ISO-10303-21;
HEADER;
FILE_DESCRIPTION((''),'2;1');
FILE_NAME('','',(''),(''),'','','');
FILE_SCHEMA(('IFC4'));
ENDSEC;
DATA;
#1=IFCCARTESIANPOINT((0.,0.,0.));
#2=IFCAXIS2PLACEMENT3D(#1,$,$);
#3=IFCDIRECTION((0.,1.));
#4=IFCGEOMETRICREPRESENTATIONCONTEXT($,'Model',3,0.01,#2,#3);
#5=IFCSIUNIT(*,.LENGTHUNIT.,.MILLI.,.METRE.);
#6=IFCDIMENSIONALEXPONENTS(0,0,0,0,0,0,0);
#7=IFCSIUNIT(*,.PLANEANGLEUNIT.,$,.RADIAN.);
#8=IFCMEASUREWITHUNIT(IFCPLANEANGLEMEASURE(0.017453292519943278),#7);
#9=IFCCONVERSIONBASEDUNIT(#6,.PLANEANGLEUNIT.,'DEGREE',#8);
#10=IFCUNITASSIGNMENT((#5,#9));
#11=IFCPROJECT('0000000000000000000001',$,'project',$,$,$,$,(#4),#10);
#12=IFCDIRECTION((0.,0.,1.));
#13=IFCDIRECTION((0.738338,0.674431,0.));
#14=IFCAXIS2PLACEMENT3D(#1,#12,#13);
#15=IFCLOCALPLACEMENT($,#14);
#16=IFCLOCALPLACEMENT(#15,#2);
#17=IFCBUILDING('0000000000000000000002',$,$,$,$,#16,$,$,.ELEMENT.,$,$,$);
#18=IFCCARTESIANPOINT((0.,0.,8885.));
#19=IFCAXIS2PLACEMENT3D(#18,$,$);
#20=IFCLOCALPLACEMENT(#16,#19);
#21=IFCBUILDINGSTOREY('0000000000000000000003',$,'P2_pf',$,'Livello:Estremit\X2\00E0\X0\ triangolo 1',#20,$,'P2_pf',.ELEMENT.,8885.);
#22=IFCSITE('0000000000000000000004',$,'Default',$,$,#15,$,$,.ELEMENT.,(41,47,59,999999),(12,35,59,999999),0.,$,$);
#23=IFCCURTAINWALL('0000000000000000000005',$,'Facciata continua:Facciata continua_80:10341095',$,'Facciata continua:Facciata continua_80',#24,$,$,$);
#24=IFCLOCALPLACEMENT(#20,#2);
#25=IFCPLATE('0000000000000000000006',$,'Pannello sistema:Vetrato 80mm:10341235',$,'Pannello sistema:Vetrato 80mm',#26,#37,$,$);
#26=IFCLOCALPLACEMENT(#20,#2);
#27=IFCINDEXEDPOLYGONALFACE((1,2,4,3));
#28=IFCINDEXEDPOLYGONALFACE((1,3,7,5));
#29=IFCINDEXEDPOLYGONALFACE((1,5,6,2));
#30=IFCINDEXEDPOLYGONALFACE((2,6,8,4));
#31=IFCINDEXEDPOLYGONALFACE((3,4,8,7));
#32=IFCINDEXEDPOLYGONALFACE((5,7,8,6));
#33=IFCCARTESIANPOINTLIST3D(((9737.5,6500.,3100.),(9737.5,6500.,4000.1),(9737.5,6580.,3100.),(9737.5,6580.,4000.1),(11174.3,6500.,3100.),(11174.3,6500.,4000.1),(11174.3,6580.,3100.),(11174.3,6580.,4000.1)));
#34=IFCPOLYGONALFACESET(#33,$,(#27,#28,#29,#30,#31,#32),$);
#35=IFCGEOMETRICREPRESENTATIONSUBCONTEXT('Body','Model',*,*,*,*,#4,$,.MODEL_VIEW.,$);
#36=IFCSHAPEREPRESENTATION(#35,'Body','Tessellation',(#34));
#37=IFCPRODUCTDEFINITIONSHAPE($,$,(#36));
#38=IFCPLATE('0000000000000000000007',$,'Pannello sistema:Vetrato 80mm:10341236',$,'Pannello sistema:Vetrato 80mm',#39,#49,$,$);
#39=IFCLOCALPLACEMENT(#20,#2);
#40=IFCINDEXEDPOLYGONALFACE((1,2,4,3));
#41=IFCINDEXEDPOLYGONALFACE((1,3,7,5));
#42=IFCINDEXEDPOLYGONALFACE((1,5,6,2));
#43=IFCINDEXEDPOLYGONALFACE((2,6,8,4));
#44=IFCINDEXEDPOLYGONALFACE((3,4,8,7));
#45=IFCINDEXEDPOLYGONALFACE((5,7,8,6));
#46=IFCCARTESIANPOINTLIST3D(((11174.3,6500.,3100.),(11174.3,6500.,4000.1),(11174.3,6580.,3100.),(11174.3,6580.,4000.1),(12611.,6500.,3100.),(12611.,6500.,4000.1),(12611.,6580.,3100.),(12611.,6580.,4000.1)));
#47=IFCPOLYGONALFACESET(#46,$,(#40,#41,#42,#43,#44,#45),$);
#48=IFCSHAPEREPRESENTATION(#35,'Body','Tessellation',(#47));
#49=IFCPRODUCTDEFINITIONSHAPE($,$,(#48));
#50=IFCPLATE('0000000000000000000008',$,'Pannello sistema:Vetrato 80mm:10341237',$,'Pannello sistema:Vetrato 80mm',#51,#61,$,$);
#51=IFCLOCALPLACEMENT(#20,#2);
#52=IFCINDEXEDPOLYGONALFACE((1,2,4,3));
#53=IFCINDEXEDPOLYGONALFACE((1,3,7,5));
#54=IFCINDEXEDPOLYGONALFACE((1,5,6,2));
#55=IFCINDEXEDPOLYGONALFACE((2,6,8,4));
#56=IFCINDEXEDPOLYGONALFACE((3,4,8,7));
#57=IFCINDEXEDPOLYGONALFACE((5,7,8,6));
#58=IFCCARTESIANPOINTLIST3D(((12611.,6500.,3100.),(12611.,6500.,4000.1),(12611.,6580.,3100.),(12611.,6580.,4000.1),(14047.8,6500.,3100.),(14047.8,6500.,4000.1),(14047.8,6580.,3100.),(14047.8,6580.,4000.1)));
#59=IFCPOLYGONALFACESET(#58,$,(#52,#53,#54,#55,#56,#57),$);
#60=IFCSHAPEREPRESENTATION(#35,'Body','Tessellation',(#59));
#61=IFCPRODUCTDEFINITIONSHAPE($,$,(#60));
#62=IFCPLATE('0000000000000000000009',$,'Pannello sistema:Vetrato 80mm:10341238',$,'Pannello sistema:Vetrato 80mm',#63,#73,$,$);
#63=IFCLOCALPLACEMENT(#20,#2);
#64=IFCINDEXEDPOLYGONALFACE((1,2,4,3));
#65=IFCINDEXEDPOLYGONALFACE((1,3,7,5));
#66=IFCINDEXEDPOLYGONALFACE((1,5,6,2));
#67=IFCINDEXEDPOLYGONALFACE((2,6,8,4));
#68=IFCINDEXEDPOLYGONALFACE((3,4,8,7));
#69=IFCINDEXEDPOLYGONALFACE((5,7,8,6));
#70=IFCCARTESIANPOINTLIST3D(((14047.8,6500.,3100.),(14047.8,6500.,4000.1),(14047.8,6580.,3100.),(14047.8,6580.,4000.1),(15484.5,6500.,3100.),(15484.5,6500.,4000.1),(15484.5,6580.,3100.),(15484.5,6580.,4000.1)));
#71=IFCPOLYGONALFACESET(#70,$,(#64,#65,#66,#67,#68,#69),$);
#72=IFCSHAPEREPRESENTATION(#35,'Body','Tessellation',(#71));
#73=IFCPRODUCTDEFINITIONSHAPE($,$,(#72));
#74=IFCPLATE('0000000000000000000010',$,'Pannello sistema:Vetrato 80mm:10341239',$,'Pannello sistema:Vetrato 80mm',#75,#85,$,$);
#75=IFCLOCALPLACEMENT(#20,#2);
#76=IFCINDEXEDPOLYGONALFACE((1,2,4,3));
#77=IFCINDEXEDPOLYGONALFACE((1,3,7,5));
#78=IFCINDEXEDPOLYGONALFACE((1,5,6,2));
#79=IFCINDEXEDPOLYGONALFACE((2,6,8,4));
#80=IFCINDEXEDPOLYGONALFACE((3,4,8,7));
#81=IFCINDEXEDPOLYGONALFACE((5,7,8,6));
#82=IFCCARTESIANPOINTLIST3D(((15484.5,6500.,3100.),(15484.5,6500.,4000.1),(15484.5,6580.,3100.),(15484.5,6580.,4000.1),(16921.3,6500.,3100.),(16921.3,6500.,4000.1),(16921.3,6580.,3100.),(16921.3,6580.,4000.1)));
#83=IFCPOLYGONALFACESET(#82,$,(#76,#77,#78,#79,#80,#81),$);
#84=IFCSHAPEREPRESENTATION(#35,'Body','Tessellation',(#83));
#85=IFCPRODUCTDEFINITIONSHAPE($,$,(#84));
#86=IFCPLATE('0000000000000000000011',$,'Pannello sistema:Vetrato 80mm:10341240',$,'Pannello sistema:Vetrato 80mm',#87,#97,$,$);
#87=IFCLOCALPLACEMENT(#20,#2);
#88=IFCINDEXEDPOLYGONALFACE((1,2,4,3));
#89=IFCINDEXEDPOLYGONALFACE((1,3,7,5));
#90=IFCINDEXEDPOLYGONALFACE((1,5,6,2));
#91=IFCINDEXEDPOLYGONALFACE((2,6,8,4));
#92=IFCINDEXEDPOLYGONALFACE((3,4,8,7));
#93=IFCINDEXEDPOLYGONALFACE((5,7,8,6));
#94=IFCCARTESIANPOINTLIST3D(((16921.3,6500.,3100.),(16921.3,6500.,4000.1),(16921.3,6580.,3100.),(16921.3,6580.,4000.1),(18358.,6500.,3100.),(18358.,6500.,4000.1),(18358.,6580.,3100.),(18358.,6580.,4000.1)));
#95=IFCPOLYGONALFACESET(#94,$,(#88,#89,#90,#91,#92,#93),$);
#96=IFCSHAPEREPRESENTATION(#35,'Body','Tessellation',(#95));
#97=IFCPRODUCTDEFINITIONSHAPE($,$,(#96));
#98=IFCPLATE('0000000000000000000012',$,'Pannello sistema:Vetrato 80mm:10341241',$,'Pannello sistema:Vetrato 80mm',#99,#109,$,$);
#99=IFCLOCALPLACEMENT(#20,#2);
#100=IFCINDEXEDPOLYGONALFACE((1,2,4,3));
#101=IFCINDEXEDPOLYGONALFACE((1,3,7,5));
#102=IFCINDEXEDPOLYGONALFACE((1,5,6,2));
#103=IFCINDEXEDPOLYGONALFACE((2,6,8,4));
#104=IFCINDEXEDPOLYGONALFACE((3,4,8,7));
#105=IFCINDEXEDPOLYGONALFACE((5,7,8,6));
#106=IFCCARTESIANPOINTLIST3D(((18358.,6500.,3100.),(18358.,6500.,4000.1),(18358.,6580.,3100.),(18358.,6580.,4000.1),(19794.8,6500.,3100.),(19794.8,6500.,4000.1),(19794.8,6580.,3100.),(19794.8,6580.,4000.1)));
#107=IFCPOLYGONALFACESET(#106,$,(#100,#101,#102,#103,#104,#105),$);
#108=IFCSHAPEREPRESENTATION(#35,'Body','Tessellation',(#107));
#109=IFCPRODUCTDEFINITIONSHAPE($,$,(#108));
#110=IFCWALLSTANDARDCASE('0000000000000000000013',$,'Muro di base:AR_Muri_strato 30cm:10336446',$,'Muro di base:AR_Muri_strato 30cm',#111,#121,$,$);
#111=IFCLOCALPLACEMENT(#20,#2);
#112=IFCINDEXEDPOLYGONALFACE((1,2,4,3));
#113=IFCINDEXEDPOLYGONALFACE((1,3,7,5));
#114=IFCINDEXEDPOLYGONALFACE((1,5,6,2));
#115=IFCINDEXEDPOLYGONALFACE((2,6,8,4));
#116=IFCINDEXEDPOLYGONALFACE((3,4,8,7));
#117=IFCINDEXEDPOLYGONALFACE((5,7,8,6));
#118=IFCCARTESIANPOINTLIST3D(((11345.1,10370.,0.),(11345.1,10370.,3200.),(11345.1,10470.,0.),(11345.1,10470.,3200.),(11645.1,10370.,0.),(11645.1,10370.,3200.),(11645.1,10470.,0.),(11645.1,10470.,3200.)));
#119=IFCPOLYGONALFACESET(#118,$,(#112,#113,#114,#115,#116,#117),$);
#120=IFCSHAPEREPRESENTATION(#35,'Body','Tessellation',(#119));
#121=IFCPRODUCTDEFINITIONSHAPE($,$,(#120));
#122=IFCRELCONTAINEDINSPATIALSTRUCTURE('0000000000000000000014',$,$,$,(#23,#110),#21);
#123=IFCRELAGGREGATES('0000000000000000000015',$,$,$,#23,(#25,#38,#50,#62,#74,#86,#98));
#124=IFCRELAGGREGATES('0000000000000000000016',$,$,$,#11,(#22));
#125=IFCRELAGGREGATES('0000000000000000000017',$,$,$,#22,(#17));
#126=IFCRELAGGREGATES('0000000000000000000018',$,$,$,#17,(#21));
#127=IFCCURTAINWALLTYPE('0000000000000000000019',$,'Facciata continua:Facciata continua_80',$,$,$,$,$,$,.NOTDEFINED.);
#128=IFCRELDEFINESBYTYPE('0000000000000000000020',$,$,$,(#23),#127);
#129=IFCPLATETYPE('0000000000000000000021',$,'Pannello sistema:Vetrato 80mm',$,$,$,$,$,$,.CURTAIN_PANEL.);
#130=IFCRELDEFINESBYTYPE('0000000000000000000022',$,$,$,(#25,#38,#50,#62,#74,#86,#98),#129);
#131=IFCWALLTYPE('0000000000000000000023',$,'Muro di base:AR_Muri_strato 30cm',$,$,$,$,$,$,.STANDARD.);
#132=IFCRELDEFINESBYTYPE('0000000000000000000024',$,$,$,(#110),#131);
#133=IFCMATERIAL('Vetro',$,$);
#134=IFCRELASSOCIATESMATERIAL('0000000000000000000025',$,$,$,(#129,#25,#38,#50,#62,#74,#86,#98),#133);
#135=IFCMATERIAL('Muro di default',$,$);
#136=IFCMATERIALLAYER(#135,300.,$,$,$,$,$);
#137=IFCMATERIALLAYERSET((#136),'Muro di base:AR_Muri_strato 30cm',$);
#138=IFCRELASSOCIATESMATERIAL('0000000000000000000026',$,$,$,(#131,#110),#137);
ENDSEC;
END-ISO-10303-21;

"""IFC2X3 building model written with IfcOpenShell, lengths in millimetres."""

from ifc_helpers import new_model, entity, si_unit, converted_unit, direction, frame, frame_2d, origin, origin_2d_with_axis, place, context, subcontext, project, spatial, rectangle, extrude, source, transform, mapped, material, layer, layer_set, layer_usage, type_object, type_shapes, element, aggregate, save


model = new_model("IFC2X3")

# Units and contexts
model_context = context("Model", 3, precision=0.01, world=origin(), true_north=direction((0.0, 1.0)))
body_context = subcontext(model_context, "Body", "Model", "MODEL_VIEW")
ifc_project = project(units=[si_unit("LENGTHUNIT", "METRE", prefix="MILLI"), converted_unit("PLANEANGLEUNIT", "DEGREE", entity("IfcPlaneAngleMeasure", 0.017453292519943278), si_unit("PLANEANGLEUNIT", "RADIAN"), dimensions=[0, 0, 0, 0, 0, 0, 0])], contexts=[model_context])

# Site, building, storey
site_placement = place(None, frame((0.0, 0.0, 0.0), z_axis=(0.0, 0.0, 1.0), x_axis=(0.738338, 0.674431, 0.0)))
site = spatial("IfcSite", under=ifc_project, at=site_placement, Name="Default", CompositionType="ELEMENT", RefLatitude=(41, 47, 59, 999999), RefLongitude=(12, 35, 59, 999999), RefElevation=0.0)
building_placement = place(site_placement, origin())
building = spatial("IfcBuilding", under=site, at=building_placement, CompositionType="ELEMENT")
storey_placement = place(building_placement, frame((0.0, 0.0, 8885.0)))
storey = spatial("IfcBuildingStorey", under=building, at=storey_placement, Name="P2_pf", ObjectType="Livello:Estremità triangolo 1", LongName="P2_pf", CompositionType="ELEMENT", Elevation=8885.0)

# Curtain wall, plates
curtain_wall_type = type_object("IfcCurtainWallType", Name="Facciata continua:Facciata continua_80", PredefinedType="NOTDEFINED")
curtain_wall_placement = place(storey_placement, frame((0.0, 0.0, -8885.0)))
curtain_wall = element("IfcCurtainWall", 1, at=curtain_wall_placement, inside=storey, type_object=curtain_wall_type, Name="Facciata continua:Facciata continua_80:10341095", ObjectType="Facciata continua:Facciata continua_80")
ifc_material_1 = material(Name="Vetro")
plate_type_1 = type_object("IfcPlateType", Name="Pannello sistema:Vetrato 80mm", PredefinedType="CURTAIN_PANEL", material=ifc_material_1)
shared_shape_1 = source(origin(), body_context, "Body", "SweptSolid", [
    extrude(rectangle(XDim=80.0, YDim=1436.8, at=origin_2d_with_axis()), frame((0.0, -40.0, 0.0), z_axis=(0.0, 0.0, 1.0), x_axis=(0.0, 1.0, 0.0)), (0.0, 0.0, 1.0), 900.1),
])
type_shapes(plate_type_1, [shared_shape_1])
plate_1_placement = place(curtain_wall_placement, frame((10455.9, 6580.0, 11985.0)))
plate_1 = element("IfcPlate", 2, at=plate_1_placement, type_object=plate_type_1, material=ifc_material_1, Name="Pannello sistema:Vetrato 80mm:10341235", ObjectType="Pannello sistema:Vetrato 80mm", context=body_context, shape_type="MappedRepresentation", body=[
    mapped(shared_shape_1, transform((0.0, 0.0, 0.0), scale=1.0)),
])
plate_2_placement = place(curtain_wall_placement, frame((11892.6, 6580.0, 11985.0)))
plate_2 = element("IfcPlate", 3, at=plate_2_placement, type_object=plate_type_1, material=ifc_material_1, Name="Pannello sistema:Vetrato 80mm:10341236", ObjectType="Pannello sistema:Vetrato 80mm", context=body_context, shape_type="MappedRepresentation", body=[
    mapped(shared_shape_1, transform((0.0, 0.0, 0.0), scale=1.0)),
])
plate_3_placement = place(curtain_wall_placement, frame((13329.4, 6580.0, 11985.0)))
plate_3 = element("IfcPlate", 4, at=plate_3_placement, type_object=plate_type_1, material=ifc_material_1, Name="Pannello sistema:Vetrato 80mm:10341237", ObjectType="Pannello sistema:Vetrato 80mm", context=body_context, shape_type="MappedRepresentation", body=[
    mapped(shared_shape_1, transform((0.0, 0.0, 0.0), scale=1.0)),
])
plate_4_placement = place(curtain_wall_placement, frame((14766.1, 6580.0, 11985.0)))
plate_4 = element("IfcPlate", 5, at=plate_4_placement, type_object=plate_type_1, material=ifc_material_1, Name="Pannello sistema:Vetrato 80mm:10341238", ObjectType="Pannello sistema:Vetrato 80mm", context=body_context, shape_type="MappedRepresentation", body=[
    mapped(shared_shape_1, transform((0.0, 0.0, 0.0), scale=1.0)),
])
plate_5_placement = place(curtain_wall_placement, frame((16202.9, 6580.0, 11985.0)))
plate_5 = element("IfcPlate", 6, at=plate_5_placement, type_object=plate_type_1, material=ifc_material_1, Name="Pannello sistema:Vetrato 80mm:10341239", ObjectType="Pannello sistema:Vetrato 80mm", context=body_context, shape_type="MappedRepresentation", body=[
    mapped(shared_shape_1, transform((0.0, 0.0, 0.0), scale=1.0)),
])
plate_6_placement = place(curtain_wall_placement, frame((17639.6, 6580.0, 11985.0)))
plate_6 = element("IfcPlate", 7, at=plate_6_placement, type_object=plate_type_1, material=ifc_material_1, Name="Pannello sistema:Vetrato 80mm:10341240", ObjectType="Pannello sistema:Vetrato 80mm", context=body_context, shape_type="MappedRepresentation", body=[
    mapped(shared_shape_1, transform((0.0, 0.0, 0.0), scale=1.0)),
])
plate_7_placement = place(curtain_wall_placement, frame((19076.4, 6580.0, 11985.0)))
plate_7 = element("IfcPlate", 8, at=plate_7_placement, type_object=plate_type_1, material=ifc_material_1, Name="Pannello sistema:Vetrato 80mm:10341241", ObjectType="Pannello sistema:Vetrato 80mm", context=body_context, shape_type="MappedRepresentation", body=[
    mapped(shared_shape_1, transform((0.0, 0.0, 0.0), scale=1.0)),
])
aggregate(curtain_wall, [plate_1, plate_2, plate_3, plate_4, plate_5, plate_6, plate_7])

# Wall
ifc_material_2 = material(Name="Muro di default")
ifc_layer_1 = layer(ifc_material_2, 300.0)
ifc_layer_set_1 = layer_set([ifc_layer_1], Name="Muro di base:AR_Muri_strato 30cm")
ifc_layer_usage_1 = layer_usage(ifc_layer_set_1, "AXIS2", "POSITIVE", -150.0)
wall_type = type_object("IfcWallType", Name="Muro di base:AR_Muri_strato 30cm", PredefinedType="STANDARD", material=ifc_layer_set_1)
wall_placement = place(storey_placement, frame((11495.1, 10470.0, 0.0), z_axis=(0.0, 0.0, 1.0), x_axis=(0.0, -1.0, 0.0)))
element("IfcWallStandardCase", 9, at=wall_placement, inside=storey, type_object=wall_type, material=ifc_layer_usage_1, Name="Muro di base:AR_Muri_strato 30cm:10336446", ObjectType="Muro di base:AR_Muri_strato 30cm", context=body_context, shape_type="SweptSolid", body=[
    extrude(rectangle(XDim=100.0, YDim=300.0, at=frame_2d((50.0, 0.0), x_axis=(-1.0, 0.0))), origin(), (0.0, 0.0, 1.0), 3200.0),
])

save(model, "model.ifc")
